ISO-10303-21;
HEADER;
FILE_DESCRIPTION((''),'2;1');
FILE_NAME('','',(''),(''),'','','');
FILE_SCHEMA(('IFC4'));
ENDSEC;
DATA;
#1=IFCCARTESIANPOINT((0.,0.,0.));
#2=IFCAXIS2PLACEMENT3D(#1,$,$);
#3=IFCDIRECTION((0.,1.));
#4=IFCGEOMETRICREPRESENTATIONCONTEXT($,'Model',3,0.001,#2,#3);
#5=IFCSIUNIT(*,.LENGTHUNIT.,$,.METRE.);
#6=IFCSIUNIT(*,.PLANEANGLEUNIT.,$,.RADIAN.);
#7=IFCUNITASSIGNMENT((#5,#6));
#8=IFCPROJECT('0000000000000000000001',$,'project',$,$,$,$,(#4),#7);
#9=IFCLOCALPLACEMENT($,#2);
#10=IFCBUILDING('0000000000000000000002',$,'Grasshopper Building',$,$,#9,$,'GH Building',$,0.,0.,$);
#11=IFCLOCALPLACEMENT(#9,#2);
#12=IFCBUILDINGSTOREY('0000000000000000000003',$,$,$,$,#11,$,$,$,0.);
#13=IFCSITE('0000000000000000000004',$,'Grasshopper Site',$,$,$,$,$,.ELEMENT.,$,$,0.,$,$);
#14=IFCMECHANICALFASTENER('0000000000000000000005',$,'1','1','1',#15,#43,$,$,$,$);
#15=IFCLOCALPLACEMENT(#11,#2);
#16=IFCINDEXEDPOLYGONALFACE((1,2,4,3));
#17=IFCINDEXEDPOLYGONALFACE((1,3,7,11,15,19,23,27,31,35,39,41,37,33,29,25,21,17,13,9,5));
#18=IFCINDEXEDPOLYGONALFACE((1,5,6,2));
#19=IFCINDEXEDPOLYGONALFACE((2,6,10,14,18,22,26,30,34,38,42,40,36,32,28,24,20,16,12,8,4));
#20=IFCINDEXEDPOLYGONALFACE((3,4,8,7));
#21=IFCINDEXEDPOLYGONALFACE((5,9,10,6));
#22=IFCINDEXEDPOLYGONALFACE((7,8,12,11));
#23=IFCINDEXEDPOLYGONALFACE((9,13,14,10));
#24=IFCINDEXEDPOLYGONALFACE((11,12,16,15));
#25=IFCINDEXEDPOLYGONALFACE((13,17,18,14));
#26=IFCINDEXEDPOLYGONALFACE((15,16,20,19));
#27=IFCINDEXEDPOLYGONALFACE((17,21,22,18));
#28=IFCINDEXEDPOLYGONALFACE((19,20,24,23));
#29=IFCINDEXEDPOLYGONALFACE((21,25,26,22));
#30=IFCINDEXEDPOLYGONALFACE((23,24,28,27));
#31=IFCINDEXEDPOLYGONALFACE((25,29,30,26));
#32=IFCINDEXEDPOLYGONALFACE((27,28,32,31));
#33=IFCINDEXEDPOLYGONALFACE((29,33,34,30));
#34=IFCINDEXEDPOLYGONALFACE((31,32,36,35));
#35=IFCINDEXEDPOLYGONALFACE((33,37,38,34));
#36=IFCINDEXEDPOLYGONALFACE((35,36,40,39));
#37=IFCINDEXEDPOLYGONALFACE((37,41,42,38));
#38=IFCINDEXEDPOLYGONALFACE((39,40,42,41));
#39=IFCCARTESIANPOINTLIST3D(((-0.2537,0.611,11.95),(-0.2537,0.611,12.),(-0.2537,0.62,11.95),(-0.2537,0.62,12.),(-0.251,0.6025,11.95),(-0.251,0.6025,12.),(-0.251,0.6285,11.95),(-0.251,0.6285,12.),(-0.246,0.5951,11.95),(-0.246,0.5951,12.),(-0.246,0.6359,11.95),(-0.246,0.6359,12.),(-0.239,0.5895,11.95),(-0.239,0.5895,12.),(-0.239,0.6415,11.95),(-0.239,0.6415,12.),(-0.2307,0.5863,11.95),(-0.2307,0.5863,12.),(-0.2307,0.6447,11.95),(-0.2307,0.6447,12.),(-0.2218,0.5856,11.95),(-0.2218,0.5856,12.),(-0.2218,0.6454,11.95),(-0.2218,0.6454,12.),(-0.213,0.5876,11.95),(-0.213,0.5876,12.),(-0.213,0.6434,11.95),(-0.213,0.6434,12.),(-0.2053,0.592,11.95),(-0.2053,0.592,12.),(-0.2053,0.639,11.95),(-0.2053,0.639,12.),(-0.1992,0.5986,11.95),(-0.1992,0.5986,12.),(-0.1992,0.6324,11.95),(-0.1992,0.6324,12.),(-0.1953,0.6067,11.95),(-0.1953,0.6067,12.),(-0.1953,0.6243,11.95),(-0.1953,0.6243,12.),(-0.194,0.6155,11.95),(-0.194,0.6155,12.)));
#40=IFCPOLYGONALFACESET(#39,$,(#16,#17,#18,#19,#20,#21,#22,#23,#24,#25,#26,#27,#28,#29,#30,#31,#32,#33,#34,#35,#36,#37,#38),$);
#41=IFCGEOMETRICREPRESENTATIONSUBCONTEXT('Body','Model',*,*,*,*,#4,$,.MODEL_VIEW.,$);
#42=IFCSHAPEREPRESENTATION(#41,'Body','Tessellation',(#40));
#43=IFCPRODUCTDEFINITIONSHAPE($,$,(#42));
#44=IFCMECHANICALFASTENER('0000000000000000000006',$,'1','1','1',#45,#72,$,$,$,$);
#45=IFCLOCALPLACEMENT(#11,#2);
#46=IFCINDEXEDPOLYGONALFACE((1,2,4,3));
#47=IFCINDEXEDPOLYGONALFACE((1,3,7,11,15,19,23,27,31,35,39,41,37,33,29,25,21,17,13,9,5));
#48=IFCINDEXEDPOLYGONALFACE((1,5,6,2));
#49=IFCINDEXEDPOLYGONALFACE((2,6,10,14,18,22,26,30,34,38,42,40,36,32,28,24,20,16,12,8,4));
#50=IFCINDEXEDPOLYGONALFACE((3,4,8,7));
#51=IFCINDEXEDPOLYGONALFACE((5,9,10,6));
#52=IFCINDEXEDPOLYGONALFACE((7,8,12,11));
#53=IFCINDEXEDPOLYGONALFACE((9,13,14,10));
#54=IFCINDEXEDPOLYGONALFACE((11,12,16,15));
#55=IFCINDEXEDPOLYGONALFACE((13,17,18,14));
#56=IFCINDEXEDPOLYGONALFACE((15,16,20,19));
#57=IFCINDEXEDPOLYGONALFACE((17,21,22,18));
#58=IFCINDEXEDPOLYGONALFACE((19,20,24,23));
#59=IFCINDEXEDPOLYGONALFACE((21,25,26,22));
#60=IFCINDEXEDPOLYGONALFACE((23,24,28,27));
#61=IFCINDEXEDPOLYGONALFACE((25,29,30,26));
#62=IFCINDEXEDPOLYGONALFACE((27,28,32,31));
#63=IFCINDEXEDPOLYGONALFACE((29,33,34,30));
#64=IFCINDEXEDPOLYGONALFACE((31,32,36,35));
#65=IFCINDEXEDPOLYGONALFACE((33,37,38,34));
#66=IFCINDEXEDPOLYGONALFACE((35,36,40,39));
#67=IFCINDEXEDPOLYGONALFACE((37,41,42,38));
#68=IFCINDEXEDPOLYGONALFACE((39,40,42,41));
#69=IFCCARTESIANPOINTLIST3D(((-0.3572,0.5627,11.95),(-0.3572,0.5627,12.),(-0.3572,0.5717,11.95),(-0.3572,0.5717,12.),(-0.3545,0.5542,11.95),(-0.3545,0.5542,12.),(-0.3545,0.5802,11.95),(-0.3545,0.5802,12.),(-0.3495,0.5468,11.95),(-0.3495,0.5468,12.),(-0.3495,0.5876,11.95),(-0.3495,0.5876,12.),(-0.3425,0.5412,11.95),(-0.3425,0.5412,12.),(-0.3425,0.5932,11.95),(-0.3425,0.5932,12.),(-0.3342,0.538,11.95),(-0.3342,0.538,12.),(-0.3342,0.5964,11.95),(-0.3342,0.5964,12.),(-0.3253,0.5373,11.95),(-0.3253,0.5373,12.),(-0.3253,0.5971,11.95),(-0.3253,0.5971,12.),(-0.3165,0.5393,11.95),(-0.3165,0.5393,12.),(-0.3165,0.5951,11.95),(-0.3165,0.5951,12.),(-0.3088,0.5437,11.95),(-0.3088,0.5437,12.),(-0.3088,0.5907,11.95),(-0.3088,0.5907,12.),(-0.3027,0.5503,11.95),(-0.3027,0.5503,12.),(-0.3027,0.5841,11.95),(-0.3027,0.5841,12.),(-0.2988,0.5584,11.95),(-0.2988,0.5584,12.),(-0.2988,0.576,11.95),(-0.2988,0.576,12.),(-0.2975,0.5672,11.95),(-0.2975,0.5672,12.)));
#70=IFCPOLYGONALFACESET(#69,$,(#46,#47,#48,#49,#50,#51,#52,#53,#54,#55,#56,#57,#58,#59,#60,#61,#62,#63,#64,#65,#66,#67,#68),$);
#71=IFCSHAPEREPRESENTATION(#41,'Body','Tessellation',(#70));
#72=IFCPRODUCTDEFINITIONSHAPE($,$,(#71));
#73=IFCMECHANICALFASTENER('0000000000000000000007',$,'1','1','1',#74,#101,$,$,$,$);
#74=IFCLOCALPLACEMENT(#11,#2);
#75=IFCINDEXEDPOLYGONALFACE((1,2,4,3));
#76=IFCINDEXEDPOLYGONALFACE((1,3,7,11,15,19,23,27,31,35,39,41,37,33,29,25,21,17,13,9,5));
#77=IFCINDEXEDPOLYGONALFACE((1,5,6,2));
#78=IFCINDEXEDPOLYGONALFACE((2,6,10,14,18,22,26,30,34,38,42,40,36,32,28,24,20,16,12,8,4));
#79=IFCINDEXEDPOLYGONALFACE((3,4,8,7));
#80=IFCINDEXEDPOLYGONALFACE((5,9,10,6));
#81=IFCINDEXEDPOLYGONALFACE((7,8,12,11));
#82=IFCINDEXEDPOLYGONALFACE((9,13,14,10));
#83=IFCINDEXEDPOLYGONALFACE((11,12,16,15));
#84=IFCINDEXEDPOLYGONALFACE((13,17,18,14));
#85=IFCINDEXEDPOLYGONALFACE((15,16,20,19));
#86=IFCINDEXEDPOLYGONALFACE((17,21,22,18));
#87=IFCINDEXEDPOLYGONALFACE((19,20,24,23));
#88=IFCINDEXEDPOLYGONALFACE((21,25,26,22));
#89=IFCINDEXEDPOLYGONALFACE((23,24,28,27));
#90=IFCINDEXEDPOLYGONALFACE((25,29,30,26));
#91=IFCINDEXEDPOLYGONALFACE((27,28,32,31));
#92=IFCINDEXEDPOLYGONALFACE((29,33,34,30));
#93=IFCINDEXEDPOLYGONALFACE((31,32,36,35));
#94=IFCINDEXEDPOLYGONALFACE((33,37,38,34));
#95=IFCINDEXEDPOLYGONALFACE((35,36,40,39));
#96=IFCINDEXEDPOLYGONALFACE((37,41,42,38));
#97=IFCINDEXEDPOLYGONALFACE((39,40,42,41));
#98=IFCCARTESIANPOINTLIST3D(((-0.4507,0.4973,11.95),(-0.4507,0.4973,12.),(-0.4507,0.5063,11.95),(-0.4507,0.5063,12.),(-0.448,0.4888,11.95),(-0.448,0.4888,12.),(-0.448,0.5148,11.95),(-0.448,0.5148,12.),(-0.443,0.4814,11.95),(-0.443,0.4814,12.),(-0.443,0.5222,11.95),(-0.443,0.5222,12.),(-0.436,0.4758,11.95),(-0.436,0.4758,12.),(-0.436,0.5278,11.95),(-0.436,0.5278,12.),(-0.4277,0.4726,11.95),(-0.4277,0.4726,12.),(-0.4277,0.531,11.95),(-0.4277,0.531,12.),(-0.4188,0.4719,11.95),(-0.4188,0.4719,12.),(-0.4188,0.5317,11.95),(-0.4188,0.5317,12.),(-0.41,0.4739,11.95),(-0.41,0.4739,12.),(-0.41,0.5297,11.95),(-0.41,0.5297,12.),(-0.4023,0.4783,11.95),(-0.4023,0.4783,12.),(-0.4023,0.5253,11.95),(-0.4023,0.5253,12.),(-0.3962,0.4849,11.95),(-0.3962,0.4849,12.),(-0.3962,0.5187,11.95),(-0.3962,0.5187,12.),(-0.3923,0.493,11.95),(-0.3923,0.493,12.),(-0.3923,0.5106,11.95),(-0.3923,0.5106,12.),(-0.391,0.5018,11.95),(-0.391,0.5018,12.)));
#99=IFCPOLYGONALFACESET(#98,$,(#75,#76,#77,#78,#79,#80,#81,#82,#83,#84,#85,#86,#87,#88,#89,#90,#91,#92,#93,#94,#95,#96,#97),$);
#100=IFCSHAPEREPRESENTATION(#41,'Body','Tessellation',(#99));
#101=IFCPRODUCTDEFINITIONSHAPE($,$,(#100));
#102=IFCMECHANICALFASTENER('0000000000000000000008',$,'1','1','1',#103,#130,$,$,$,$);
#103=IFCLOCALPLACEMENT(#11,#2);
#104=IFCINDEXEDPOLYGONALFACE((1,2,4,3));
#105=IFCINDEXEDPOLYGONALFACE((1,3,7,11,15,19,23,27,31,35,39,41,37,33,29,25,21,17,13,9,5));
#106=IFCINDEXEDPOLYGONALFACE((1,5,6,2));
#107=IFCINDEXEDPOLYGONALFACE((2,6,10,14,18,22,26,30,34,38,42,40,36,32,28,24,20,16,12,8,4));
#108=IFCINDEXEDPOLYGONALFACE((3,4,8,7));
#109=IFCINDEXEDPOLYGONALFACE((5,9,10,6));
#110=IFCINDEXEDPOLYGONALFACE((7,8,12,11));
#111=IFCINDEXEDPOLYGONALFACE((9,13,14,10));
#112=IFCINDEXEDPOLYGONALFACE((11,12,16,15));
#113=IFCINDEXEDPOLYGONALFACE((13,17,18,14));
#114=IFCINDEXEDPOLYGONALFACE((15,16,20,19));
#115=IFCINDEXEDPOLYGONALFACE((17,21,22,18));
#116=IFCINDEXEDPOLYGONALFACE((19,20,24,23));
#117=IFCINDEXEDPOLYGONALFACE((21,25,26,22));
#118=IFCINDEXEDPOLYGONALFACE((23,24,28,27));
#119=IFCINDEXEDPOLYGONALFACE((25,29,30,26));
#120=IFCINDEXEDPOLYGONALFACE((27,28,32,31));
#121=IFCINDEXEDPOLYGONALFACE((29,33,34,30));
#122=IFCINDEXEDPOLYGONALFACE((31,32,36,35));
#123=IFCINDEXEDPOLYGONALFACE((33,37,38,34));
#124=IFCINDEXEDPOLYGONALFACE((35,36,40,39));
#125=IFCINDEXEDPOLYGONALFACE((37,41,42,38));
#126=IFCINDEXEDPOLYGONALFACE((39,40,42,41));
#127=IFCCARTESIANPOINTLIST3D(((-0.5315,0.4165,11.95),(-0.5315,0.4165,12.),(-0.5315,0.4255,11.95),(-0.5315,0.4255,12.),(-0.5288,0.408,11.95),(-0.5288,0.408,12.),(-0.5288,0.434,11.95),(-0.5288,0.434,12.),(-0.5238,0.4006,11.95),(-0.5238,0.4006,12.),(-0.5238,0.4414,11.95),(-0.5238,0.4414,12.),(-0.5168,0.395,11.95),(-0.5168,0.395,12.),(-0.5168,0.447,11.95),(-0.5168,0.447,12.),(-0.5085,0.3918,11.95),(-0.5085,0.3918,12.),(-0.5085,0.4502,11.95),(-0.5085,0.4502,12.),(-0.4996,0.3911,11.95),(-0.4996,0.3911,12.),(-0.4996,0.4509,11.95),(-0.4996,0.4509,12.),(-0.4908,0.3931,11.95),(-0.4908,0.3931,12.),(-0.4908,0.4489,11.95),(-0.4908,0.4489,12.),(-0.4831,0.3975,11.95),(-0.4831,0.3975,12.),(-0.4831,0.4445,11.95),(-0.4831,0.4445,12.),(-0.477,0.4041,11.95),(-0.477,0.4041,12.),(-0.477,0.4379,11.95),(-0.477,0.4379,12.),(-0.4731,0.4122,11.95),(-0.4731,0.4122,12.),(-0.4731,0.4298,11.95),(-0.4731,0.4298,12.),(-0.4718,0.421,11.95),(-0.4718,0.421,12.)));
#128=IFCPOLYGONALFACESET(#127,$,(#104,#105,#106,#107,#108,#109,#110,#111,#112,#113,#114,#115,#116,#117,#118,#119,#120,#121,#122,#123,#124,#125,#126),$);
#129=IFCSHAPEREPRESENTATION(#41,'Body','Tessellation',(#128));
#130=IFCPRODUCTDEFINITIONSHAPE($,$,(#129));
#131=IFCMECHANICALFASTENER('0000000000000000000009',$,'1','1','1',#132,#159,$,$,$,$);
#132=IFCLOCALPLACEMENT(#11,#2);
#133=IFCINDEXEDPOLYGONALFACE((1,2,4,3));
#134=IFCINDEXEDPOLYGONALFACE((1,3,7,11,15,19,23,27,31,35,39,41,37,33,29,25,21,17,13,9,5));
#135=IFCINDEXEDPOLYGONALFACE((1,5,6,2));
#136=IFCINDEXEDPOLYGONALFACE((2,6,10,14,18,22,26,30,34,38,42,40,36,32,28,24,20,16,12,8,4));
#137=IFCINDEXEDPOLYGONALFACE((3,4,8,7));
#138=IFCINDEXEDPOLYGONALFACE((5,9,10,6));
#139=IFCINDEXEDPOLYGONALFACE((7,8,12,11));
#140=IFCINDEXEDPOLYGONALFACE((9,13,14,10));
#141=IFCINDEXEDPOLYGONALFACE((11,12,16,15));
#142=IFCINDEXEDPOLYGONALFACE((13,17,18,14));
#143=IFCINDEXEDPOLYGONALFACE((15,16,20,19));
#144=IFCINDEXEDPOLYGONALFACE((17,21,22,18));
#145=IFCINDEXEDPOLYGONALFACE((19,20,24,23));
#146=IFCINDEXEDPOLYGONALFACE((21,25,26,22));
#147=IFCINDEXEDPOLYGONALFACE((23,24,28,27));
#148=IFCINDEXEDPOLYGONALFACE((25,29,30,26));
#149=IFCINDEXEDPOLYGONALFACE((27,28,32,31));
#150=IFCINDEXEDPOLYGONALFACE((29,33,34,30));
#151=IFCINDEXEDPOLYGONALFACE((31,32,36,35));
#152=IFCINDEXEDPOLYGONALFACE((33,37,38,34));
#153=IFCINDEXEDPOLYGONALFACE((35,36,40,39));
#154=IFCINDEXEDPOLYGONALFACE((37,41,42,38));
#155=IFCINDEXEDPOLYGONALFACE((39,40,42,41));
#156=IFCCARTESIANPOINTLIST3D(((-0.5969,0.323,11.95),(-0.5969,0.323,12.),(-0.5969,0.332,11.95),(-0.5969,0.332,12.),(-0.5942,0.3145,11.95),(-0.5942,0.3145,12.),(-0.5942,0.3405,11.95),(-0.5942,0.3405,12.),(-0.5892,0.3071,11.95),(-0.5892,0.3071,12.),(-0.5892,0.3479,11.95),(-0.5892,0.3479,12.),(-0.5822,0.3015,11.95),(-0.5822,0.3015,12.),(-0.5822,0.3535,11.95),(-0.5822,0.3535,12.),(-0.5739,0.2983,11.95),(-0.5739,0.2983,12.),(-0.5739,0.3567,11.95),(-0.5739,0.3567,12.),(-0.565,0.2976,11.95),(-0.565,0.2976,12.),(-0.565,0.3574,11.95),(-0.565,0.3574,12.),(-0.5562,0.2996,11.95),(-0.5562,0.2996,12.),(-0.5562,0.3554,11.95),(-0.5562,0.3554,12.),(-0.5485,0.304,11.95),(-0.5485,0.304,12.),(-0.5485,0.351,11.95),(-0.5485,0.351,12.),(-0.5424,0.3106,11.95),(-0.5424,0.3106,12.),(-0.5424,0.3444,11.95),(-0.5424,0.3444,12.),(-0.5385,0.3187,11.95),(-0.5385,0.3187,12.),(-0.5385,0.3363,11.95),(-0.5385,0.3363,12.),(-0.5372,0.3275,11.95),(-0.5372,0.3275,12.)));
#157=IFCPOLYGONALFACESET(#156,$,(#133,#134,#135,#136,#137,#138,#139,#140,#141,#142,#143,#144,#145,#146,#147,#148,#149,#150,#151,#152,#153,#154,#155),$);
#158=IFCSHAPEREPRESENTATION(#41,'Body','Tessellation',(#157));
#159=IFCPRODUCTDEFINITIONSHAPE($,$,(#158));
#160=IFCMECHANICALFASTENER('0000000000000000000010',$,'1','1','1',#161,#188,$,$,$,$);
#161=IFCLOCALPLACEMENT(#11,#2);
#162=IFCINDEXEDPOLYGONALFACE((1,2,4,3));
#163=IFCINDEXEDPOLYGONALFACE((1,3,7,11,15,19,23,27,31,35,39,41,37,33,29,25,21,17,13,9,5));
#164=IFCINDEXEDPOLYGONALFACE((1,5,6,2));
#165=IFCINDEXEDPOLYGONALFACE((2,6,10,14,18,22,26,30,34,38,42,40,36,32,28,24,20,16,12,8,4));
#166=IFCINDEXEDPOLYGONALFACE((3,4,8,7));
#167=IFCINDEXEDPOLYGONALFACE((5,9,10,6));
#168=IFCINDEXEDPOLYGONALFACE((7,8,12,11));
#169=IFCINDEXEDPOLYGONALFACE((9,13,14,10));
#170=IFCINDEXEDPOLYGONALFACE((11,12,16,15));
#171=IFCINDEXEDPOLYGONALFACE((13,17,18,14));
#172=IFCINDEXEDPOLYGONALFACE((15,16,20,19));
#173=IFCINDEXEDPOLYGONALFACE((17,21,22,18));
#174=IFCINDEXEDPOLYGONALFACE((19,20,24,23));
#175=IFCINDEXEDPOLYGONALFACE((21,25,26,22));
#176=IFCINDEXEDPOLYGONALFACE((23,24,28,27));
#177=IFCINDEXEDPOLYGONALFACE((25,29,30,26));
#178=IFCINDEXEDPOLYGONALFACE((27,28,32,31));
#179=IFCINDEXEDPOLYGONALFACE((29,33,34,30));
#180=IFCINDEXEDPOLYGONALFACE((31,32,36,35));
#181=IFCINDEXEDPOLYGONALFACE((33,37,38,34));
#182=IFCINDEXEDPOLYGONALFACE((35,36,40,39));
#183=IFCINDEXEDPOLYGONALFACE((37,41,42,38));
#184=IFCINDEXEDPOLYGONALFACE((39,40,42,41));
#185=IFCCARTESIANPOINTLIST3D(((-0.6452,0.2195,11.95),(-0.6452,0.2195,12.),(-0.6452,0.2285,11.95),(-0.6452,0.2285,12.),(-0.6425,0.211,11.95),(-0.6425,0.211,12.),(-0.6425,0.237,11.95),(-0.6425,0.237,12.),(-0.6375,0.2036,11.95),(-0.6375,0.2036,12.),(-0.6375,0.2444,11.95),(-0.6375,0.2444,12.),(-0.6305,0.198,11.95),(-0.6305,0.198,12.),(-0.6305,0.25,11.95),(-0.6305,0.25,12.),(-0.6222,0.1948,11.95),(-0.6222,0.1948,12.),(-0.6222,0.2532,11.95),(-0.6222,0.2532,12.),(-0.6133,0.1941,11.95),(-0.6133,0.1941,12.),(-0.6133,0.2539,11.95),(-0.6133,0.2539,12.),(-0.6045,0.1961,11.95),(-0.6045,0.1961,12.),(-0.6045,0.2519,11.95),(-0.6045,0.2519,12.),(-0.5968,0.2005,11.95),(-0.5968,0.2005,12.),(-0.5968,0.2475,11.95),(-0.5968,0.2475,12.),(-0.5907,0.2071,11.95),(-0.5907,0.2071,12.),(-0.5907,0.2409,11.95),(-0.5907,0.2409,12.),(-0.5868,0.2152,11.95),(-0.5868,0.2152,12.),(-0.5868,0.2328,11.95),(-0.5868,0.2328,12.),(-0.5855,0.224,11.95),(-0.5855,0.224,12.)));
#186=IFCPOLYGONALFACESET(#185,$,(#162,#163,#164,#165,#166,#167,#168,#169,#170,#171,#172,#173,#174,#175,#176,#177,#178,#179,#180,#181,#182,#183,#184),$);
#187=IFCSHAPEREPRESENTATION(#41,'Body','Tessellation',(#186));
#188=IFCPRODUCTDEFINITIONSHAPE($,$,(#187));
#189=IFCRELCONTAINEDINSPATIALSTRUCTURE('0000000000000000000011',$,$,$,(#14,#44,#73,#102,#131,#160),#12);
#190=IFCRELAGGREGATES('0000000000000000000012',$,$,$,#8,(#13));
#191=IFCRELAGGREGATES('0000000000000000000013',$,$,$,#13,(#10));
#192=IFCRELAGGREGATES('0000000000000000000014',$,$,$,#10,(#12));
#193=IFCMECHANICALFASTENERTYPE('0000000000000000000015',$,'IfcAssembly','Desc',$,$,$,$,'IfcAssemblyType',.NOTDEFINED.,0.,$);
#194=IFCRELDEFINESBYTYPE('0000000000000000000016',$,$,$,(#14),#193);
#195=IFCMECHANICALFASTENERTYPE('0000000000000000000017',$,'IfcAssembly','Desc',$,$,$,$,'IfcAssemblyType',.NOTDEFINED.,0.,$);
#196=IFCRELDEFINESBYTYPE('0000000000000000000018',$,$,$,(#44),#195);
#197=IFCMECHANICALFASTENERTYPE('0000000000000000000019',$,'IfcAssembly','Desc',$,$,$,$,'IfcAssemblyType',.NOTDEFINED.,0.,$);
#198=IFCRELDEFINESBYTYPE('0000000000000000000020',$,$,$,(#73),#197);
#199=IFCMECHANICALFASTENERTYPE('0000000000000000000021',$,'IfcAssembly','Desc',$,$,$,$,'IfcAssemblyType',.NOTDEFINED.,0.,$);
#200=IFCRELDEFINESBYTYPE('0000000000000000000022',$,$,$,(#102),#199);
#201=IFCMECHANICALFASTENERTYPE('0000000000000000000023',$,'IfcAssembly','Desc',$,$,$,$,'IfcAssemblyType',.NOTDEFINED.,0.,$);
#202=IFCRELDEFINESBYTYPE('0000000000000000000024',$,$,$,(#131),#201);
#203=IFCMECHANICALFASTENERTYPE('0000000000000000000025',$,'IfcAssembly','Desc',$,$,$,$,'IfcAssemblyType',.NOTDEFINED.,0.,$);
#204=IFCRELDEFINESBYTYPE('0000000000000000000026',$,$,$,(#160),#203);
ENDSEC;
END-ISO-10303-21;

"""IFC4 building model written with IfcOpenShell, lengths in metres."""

from ifc_helpers import new_model, si_unit, direction, frame, origin, place, context, subcontext, project, spatial, circle, extrude, source, transform, mapped, type_object, type_shapes, element, save


model = new_model("IFC4")

# Units and contexts
model_context = context("Model", 3, precision=0.001, world=origin(), true_north=direction((0.0, 1.0)))
body_context = subcontext(model_context, "Body", "Model", "MODEL_VIEW")
ifc_project = project(units=[si_unit("LENGTHUNIT", "METRE"), si_unit("PLANEANGLEUNIT", "RADIAN")], contexts=[model_context])

# Site, building, storey
site = spatial("IfcSite", under=ifc_project, Name="Grasshopper Site", CompositionType="ELEMENT", RefElevation=0.0)
building_placement = place(None, origin())
building = spatial("IfcBuilding", under=site, at=building_placement, Name="Grasshopper Building", LongName="GH Building", ElevationOfRefHeight=0.0, ElevationOfTerrain=0.0)
storey_placement = place(building_placement, origin())
storey = spatial("IfcBuildingStorey", under=building, at=storey_placement, Elevation=0.0)

# Mechanical fasteners
mechanical_fastener_type_1 = type_object("IfcMechanicalFastenerType", Name="IfcAssembly", Description="Desc", ElementType="IfcAssemblyType", NominalDiameter=0.0)
shared_shape_1 = source(origin(), body_context, "Body", "SweptSolid", [
    extrude(circle(Radius=0.03), frame((-0.224, 0.6155, 12.0), z_axis=(0.0, 0.0, -1.0), x_axis=(1.0, 0.0, 0.0)), (0.0, 0.0, 1.0), 0.05),
])
type_shapes(mechanical_fastener_type_1, [shared_shape_1])
mechanical_fastener_1_placement = place(storey_placement, origin())
element("IfcMechanicalFastener", 1, at=mechanical_fastener_1_placement, inside=storey, type_object=mechanical_fastener_type_1, Name="1", Description="1", ObjectType="1", context=body_context, shape_type="MappedRepresentation", body=[
    mapped(shared_shape_1, transform((0.0, 0.0, 0.0), scale=1.0)),
])
mechanical_fastener_type_2 = type_object("IfcMechanicalFastenerType", Name="IfcAssembly", Description="Desc", ElementType="IfcAssemblyType", NominalDiameter=0.0)
shared_shape_2 = source(origin(), body_context, "Body", "SweptSolid", [
    extrude(circle(Radius=0.03), frame((-0.3275, 0.5672, 12.0), z_axis=(0.0, 0.0, -1.0), x_axis=(1.0, 0.0, 0.0)), (0.0, 0.0, 1.0), 0.05),
])
type_shapes(mechanical_fastener_type_2, [shared_shape_2])
mechanical_fastener_2_placement = place(storey_placement, origin())
element("IfcMechanicalFastener", 2, at=mechanical_fastener_2_placement, inside=storey, type_object=mechanical_fastener_type_2, Name="1", Description="1", ObjectType="1", context=body_context, shape_type="MappedRepresentation", body=[
    mapped(shared_shape_2, transform((0.0, 0.0, 0.0), scale=1.0)),
])
mechanical_fastener_type_3 = type_object("IfcMechanicalFastenerType", Name="IfcAssembly", Description="Desc", ElementType="IfcAssemblyType", NominalDiameter=0.0)
shared_shape_3 = source(origin(), body_context, "Body", "SweptSolid", [
    extrude(circle(Radius=0.03), frame((-0.421, 0.5018, 12.0), z_axis=(0.0, 0.0, -1.0), x_axis=(1.0, 0.0, 0.0)), (0.0, 0.0, 1.0), 0.05),
])
type_shapes(mechanical_fastener_type_3, [shared_shape_3])
mechanical_fastener_3_placement = place(storey_placement, origin())
element("IfcMechanicalFastener", 3, at=mechanical_fastener_3_placement, inside=storey, type_object=mechanical_fastener_type_3, Name="1", Description="1", ObjectType="1", context=body_context, shape_type="MappedRepresentation", body=[
    mapped(shared_shape_3, transform((0.0, 0.0, 0.0), scale=1.0)),
])
mechanical_fastener_type_4 = type_object("IfcMechanicalFastenerType", Name="IfcAssembly", Description="Desc", ElementType="IfcAssemblyType", NominalDiameter=0.0)
shared_shape_4 = source(origin(), body_context, "Body", "SweptSolid", [
    extrude(circle(Radius=0.03), frame((-0.5018, 0.421, 12.0), z_axis=(0.0, 0.0, -1.0), x_axis=(1.0, 0.0, 0.0)), (0.0, 0.0, 1.0), 0.05),
])
type_shapes(mechanical_fastener_type_4, [shared_shape_4])
mechanical_fastener_4_placement = place(storey_placement, origin())
element("IfcMechanicalFastener", 4, at=mechanical_fastener_4_placement, inside=storey, type_object=mechanical_fastener_type_4, Name="1", Description="1", ObjectType="1", context=body_context, shape_type="MappedRepresentation", body=[
    mapped(shared_shape_4, transform((0.0, 0.0, 0.0), scale=1.0)),
])
mechanical_fastener_type_5 = type_object("IfcMechanicalFastenerType", Name="IfcAssembly", Description="Desc", ElementType="IfcAssemblyType", NominalDiameter=0.0)
shared_shape_5 = source(origin(), body_context, "Body", "SweptSolid", [
    extrude(circle(Radius=0.03), frame((-0.5672, 0.3275, 12.0), z_axis=(0.0, 0.0, -1.0), x_axis=(1.0, 0.0, 0.0)), (0.0, 0.0, 1.0), 0.05),
])
type_shapes(mechanical_fastener_type_5, [shared_shape_5])
mechanical_fastener_5_placement = place(storey_placement, origin())
element("IfcMechanicalFastener", 5, at=mechanical_fastener_5_placement, inside=storey, type_object=mechanical_fastener_type_5, Name="1", Description="1", ObjectType="1", context=body_context, shape_type="MappedRepresentation", body=[
    mapped(shared_shape_5, transform((0.0, 0.0, 0.0), scale=1.0)),
])
mechanical_fastener_type_6 = type_object("IfcMechanicalFastenerType", Name="IfcAssembly", Description="Desc", ElementType="IfcAssemblyType", NominalDiameter=0.0)
shared_shape_6 = source(origin(), body_context, "Body", "SweptSolid", [
    extrude(circle(Radius=0.03), frame((-0.6155, 0.224, 12.0), z_axis=(0.0, 0.0, -1.0), x_axis=(1.0, 0.0, 0.0)), (0.0, 0.0, 1.0), 0.05),
])
type_shapes(mechanical_fastener_type_6, [shared_shape_6])
mechanical_fastener_6_placement = place(storey_placement, origin())
element("IfcMechanicalFastener", 6, at=mechanical_fastener_6_placement, inside=storey, type_object=mechanical_fastener_type_6, Name="1", Description="1", ObjectType="1", context=body_context, shape_type="MappedRepresentation", body=[
    mapped(shared_shape_6, transform((0.0, 0.0, 0.0), scale=1.0)),
])

save(model, "model.ifc")
